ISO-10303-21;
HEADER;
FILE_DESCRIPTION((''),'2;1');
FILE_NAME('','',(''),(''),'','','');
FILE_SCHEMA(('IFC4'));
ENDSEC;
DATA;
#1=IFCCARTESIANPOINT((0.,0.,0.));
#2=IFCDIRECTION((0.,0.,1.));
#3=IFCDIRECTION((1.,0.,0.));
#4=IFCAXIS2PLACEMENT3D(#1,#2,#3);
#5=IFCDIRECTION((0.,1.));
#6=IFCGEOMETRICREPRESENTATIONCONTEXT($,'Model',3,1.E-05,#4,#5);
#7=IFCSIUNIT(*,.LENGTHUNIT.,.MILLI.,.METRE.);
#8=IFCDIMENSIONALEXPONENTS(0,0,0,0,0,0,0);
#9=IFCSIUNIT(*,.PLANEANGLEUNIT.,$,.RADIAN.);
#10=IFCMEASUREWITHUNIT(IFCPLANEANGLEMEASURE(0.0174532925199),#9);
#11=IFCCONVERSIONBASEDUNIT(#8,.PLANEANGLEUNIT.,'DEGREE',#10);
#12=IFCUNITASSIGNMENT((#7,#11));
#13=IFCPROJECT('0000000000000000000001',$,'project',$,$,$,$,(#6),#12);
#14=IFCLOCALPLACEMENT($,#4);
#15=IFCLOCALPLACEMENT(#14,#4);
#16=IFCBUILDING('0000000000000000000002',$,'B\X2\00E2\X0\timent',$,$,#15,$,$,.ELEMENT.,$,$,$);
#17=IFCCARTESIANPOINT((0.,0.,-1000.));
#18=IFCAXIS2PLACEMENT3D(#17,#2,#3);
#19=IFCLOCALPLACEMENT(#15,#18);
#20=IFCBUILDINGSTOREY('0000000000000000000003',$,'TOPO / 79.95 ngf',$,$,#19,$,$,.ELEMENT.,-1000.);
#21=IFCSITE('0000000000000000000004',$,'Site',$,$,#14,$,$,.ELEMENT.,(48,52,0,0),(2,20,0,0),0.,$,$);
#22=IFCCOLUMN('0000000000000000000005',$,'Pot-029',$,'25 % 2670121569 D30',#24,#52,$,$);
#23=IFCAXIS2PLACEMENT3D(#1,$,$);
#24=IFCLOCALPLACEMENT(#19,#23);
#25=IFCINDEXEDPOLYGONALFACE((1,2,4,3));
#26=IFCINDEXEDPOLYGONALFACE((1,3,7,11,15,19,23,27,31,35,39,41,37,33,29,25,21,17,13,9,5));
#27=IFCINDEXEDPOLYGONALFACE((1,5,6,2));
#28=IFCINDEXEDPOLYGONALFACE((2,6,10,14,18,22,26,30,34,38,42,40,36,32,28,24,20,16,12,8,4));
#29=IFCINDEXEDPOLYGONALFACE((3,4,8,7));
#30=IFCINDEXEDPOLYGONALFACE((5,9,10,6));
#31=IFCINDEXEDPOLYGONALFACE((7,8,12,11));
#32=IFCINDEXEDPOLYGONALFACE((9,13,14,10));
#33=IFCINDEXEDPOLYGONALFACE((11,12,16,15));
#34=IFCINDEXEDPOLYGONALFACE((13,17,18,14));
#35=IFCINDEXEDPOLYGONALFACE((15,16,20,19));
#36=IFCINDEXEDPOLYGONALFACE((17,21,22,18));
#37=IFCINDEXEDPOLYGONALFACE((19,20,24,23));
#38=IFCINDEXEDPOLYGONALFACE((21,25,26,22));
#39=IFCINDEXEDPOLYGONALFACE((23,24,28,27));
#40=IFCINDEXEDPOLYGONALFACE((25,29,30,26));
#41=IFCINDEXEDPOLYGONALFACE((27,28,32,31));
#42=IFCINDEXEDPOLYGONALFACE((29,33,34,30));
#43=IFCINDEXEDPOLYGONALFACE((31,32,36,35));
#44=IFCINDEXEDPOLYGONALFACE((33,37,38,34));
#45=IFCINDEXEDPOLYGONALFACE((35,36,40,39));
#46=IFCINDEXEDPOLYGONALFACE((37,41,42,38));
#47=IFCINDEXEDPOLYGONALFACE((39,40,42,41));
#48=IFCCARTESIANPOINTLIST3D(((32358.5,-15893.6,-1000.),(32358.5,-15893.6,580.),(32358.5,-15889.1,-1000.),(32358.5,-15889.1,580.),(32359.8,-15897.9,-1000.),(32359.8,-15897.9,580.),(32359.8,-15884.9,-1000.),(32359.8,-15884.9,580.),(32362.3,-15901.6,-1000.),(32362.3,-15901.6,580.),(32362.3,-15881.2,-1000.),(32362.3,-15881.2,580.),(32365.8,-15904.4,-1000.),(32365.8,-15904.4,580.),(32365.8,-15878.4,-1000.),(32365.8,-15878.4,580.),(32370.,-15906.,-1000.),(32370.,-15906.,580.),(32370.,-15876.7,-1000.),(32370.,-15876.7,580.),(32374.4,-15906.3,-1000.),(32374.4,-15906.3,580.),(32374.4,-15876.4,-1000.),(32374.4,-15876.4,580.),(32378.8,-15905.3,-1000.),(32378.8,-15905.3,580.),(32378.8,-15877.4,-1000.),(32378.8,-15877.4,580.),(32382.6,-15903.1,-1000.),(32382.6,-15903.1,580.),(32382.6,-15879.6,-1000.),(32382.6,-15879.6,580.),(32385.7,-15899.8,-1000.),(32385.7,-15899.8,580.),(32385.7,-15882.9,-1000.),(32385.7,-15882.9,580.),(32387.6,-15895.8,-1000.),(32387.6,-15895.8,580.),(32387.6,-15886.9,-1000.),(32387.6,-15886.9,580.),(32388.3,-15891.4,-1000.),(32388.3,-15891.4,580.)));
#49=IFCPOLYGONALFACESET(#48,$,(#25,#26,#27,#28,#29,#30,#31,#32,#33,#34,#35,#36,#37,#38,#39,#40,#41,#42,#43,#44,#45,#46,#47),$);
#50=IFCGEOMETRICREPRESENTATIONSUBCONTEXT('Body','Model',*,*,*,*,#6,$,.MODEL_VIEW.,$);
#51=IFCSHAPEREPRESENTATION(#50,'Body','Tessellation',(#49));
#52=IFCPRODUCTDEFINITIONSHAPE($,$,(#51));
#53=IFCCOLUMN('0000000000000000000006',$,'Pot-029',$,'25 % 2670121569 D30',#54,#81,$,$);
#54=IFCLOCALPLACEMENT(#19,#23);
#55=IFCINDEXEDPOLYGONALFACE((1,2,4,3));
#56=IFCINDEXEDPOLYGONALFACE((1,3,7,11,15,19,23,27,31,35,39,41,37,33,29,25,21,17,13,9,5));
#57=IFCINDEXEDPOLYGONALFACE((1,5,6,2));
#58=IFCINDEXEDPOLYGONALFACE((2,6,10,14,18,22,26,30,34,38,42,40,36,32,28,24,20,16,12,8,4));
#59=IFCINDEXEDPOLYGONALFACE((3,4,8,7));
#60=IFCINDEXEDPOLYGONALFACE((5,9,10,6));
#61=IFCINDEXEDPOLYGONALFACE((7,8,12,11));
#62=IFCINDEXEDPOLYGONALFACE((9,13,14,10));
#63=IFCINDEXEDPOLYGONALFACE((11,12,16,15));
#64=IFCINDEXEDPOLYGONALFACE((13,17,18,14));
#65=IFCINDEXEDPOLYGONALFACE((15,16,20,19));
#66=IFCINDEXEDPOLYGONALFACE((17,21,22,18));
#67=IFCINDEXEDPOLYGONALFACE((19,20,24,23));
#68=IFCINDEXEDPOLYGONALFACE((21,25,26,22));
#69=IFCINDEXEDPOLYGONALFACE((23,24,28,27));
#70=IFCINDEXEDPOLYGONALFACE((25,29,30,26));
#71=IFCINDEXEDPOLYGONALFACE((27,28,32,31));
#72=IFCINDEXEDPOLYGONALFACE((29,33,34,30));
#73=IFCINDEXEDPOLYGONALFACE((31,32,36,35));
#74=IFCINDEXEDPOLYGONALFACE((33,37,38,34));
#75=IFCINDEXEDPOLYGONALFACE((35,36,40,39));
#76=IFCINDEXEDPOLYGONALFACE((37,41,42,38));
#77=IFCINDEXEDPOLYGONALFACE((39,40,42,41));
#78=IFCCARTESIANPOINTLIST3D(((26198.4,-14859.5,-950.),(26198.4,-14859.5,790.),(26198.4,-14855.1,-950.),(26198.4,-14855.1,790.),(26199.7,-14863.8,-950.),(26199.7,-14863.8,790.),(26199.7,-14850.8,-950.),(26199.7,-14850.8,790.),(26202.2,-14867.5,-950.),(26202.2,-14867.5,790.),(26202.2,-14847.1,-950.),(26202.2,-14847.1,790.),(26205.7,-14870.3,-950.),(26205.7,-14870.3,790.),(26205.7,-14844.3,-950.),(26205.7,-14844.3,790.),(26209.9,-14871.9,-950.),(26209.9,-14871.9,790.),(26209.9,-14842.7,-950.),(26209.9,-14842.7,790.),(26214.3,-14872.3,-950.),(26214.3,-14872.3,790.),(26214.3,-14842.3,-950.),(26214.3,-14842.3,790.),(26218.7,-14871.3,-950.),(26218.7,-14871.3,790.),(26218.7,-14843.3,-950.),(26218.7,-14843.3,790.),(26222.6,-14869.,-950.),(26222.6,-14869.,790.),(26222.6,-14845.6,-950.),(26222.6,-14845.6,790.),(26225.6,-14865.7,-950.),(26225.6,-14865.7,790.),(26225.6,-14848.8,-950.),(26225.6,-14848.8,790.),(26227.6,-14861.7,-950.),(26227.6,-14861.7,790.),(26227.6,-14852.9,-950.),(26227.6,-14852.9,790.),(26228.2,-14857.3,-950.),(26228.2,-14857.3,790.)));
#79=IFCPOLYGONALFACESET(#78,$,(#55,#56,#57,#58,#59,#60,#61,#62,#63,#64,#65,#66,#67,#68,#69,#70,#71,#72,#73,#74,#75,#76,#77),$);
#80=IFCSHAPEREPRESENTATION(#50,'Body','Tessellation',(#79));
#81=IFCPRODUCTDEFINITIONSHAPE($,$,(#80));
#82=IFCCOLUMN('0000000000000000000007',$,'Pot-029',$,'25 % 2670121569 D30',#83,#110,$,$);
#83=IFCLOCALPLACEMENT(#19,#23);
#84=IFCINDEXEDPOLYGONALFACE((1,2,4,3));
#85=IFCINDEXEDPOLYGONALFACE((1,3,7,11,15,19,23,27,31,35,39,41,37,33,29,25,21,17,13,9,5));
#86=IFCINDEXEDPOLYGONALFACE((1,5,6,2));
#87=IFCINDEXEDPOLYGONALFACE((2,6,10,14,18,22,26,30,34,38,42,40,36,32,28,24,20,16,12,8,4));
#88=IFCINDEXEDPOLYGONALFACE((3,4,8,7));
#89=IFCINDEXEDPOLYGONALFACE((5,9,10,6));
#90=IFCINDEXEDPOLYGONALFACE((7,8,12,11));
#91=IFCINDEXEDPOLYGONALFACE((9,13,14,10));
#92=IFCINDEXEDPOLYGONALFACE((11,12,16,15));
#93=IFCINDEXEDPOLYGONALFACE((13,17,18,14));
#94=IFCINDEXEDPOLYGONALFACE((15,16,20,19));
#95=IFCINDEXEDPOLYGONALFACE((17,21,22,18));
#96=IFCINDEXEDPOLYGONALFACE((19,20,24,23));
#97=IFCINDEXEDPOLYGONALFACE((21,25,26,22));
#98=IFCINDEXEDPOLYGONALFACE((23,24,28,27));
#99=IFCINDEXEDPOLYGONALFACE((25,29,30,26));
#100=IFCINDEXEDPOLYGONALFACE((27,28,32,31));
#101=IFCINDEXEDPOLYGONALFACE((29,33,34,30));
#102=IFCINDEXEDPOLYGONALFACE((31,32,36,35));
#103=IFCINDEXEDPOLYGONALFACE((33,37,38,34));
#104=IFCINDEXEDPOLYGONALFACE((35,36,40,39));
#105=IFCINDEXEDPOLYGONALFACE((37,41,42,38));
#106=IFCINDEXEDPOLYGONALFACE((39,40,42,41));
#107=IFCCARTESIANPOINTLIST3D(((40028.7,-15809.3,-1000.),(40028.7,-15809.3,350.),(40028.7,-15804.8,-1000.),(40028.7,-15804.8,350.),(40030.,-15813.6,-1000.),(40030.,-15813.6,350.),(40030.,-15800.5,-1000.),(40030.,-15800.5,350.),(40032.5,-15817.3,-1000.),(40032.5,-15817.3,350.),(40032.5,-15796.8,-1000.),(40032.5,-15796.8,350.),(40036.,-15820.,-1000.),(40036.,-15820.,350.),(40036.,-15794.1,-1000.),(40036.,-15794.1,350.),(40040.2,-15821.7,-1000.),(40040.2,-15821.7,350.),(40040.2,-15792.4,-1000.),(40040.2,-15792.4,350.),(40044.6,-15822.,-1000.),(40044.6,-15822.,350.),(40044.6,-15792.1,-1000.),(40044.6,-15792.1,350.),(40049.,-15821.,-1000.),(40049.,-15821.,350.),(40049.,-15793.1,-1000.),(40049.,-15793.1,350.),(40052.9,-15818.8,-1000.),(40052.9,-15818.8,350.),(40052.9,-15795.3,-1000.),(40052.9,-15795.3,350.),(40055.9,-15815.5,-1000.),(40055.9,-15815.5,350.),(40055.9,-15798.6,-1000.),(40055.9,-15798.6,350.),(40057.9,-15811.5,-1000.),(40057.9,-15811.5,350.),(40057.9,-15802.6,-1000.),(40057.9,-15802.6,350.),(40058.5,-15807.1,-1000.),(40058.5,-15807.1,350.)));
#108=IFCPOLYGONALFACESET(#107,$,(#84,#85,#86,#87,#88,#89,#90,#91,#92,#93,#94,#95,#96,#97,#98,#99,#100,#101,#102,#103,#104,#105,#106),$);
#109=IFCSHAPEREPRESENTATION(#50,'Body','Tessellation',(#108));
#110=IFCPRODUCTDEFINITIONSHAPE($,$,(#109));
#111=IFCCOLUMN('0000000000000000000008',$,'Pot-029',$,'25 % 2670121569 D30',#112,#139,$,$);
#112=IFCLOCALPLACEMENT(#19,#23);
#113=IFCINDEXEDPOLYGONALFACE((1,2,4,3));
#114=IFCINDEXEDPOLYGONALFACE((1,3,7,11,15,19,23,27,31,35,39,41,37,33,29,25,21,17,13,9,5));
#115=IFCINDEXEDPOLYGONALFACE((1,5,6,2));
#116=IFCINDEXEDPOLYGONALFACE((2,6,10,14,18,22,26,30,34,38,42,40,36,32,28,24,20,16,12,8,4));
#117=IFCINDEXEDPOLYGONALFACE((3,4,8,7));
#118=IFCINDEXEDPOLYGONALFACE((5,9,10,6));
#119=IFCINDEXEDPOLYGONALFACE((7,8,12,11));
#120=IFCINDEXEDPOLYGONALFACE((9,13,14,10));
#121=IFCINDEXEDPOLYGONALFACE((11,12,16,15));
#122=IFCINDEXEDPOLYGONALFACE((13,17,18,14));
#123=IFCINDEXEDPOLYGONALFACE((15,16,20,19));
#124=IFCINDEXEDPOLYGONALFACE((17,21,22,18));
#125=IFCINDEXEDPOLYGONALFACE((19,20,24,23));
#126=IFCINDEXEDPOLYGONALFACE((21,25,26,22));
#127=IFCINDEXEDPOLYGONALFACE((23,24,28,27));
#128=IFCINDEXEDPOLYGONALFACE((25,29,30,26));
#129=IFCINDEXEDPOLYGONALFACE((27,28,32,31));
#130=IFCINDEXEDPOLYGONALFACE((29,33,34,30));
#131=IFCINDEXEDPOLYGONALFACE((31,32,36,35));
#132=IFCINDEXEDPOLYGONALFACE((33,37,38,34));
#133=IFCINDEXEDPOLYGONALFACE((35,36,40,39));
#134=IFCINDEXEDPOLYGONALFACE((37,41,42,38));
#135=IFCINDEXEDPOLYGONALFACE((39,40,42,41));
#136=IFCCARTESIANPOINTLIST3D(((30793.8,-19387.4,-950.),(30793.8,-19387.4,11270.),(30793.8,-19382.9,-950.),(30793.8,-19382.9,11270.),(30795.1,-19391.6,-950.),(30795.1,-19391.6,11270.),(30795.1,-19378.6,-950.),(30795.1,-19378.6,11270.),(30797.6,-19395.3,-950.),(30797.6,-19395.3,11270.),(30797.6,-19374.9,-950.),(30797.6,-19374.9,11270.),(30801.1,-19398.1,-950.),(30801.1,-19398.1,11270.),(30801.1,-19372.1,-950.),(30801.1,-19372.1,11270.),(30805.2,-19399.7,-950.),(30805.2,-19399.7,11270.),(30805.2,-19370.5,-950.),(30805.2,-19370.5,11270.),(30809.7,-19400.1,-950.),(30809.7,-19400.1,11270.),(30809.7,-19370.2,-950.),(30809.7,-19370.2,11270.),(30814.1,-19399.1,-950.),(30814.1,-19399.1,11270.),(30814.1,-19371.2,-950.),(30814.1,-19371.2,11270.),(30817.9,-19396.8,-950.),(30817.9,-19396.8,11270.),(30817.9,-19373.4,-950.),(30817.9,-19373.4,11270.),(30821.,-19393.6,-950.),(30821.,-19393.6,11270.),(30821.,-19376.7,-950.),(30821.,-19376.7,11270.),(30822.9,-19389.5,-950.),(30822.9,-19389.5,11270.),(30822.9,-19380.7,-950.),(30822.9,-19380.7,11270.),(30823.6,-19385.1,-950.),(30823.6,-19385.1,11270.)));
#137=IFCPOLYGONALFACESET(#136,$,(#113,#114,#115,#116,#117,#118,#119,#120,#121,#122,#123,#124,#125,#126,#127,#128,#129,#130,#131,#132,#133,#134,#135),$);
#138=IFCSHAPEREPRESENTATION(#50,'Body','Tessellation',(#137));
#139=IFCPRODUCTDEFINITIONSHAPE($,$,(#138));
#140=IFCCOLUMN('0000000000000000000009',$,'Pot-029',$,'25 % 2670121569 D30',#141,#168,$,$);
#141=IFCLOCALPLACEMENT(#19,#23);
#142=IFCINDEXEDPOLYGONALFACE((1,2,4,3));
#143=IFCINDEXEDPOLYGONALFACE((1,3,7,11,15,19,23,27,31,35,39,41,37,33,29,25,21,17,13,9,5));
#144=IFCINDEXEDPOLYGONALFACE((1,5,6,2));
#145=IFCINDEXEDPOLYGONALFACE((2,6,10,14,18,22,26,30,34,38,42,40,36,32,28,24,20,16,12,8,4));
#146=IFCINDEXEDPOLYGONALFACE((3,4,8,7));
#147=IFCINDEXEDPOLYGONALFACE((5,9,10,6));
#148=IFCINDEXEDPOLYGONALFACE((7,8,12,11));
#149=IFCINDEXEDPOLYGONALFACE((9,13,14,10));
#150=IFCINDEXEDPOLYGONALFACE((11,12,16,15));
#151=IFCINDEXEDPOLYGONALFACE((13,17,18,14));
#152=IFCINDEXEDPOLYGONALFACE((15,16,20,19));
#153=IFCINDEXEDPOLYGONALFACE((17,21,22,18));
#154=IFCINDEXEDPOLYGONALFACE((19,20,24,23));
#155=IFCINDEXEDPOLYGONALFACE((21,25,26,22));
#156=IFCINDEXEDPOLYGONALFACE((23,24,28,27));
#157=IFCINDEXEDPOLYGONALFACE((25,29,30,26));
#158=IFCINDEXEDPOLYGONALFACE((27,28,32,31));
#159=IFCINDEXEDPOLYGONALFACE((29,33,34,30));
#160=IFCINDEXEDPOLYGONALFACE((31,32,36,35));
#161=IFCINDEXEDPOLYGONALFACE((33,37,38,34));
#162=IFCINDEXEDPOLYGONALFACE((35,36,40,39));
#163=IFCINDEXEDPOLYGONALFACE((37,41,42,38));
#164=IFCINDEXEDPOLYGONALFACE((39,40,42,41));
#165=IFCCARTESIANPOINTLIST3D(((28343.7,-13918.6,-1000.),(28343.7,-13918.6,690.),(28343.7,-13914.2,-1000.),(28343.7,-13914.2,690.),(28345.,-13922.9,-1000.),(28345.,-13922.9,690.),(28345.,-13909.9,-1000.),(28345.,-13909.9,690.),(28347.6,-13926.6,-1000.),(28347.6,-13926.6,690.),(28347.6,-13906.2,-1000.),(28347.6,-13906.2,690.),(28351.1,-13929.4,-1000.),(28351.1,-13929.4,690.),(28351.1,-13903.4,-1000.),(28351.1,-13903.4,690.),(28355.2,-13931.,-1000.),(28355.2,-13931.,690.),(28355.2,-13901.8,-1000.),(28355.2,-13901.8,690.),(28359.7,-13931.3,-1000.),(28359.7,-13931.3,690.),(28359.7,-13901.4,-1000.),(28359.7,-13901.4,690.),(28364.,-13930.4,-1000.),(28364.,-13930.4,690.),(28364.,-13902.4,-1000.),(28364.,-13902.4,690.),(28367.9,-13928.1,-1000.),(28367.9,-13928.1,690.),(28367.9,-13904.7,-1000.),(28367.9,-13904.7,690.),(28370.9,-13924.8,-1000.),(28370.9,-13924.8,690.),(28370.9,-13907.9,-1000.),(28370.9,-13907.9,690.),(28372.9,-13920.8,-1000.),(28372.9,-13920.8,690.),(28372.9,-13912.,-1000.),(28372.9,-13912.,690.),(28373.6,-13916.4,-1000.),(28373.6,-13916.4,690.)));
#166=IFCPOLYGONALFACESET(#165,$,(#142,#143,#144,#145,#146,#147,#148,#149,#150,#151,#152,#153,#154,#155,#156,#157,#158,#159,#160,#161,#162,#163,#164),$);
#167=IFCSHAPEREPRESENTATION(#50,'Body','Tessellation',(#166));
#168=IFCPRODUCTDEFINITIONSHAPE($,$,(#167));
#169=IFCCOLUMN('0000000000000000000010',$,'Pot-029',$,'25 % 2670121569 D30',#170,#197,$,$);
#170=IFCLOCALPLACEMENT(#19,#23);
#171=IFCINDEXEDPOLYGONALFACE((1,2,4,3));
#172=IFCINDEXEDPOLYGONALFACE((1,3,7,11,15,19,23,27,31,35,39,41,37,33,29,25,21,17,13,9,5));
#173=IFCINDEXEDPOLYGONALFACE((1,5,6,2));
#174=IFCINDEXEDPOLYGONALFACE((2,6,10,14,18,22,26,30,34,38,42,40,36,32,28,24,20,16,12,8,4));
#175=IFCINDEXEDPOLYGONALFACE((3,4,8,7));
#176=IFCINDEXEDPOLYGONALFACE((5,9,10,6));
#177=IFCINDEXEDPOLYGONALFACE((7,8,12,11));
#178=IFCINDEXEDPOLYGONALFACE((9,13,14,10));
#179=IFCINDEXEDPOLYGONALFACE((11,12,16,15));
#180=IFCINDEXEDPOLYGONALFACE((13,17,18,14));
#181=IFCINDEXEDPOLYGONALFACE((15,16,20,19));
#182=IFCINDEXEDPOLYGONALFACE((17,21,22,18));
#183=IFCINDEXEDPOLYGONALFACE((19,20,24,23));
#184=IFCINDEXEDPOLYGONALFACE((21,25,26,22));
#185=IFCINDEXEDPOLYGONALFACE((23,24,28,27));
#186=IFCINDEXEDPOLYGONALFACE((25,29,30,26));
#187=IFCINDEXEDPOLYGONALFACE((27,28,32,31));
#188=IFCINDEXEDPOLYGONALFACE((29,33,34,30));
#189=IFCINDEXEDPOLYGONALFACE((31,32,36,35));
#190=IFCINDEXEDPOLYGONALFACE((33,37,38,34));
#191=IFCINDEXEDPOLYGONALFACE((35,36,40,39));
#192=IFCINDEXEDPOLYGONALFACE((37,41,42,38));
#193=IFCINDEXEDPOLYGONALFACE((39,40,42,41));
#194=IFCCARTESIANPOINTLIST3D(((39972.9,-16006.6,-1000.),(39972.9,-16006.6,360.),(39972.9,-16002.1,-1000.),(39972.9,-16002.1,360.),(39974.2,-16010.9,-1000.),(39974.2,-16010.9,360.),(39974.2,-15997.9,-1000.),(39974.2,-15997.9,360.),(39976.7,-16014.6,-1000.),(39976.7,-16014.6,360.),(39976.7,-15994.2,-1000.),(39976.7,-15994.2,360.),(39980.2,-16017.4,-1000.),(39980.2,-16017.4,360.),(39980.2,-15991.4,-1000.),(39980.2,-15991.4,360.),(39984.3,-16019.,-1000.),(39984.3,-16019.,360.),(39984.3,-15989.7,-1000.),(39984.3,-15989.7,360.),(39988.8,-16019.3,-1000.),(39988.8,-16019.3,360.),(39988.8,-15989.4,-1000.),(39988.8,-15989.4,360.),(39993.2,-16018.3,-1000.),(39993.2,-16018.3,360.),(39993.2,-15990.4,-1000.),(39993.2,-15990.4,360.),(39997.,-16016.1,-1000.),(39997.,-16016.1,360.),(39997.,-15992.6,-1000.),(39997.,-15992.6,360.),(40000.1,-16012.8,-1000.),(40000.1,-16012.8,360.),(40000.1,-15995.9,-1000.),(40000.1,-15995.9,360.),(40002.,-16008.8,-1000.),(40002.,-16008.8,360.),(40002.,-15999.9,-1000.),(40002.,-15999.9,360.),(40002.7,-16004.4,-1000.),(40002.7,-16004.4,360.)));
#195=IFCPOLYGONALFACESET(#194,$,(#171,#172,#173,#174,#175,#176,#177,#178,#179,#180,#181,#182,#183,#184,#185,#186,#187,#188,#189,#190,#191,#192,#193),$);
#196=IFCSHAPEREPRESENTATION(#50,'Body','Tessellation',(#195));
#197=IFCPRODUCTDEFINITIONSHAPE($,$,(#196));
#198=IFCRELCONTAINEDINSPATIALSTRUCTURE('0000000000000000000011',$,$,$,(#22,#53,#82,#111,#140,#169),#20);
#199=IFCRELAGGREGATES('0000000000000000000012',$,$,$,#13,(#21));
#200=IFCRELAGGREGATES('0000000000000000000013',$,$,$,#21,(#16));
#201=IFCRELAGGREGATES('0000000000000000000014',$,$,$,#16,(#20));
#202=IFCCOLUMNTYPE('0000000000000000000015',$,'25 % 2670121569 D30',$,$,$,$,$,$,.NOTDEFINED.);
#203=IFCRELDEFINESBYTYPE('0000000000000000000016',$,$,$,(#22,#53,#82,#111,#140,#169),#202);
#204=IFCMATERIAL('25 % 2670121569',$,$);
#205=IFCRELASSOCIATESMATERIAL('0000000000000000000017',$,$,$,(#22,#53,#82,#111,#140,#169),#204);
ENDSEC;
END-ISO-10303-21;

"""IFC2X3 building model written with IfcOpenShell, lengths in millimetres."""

from ifc_helpers import new_model, entity, si_unit, converted_unit, direction, frame, origin_with_axes, origin_2d_with_axis, place, context, subcontext, project, spatial, circle, extrude, material, type_object, element, save


model = new_model("IFC2X3")

# Units and contexts
model_context = context("Model", 3, precision=1e-05, world=origin_with_axes(), true_north=direction((0.0, 1.0)))
body_context = subcontext(model_context, "Body", "Model", "MODEL_VIEW")
ifc_project = project(units=[si_unit("LENGTHUNIT", "METRE", prefix="MILLI"), converted_unit("PLANEANGLEUNIT", "DEGREE", entity("IfcPlaneAngleMeasure", 0.0174532925199), si_unit("PLANEANGLEUNIT", "RADIAN"), dimensions=[0, 0, 0, 0, 0, 0, 0])], contexts=[model_context])

# Site, building, storey
site_placement = place(None, origin_with_axes())
site = spatial("IfcSite", under=ifc_project, at=site_placement, Name="Site", CompositionType="ELEMENT", RefLatitude=(48, 52, 0, 0), RefLongitude=(2, 20, 0, 0), RefElevation=0.0)
building_placement = place(site_placement, origin_with_axes())
building = spatial("IfcBuilding", under=site, at=building_placement, Name="Bâtiment", CompositionType="ELEMENT")
storey_placement = place(building_placement, frame((0.0, 0.0, -1000.0), z_axis=(0.0, 0.0, 1.0), x_axis=(1.0, 0.0, 0.0)))
storey = spatial("IfcBuildingStorey", under=building, at=storey_placement, Name="TOPO / 79.95 ngf", CompositionType="ELEMENT", Elevation=-1000.0)

# Columns
ifc_material_1 = material(Name="25 % 2670121569")
column_type_1 = type_object("IfcColumnType", Name="25 % 2670121569 D30", PredefinedType="NOTDEFINED")
column_1_placement = place(storey_placement, frame((32373.3, -15891.4, -1000.0), z_axis=(0.0, 0.0, 1.0), x_axis=(1.0, 0.0, 0.0)))
element("IfcColumn", 1, at=column_1_placement, inside=storey, type_object=column_type_1, material=ifc_material_1, Name="Pot-029", ObjectType="25 % 2670121569 D30", context=body_context, shape_type="SweptSolid", body=[
    extrude(circle(Radius=15.0, at=origin_2d_with_axis()), origin_with_axes(), (0.0, 0.0, 1.0), 1580.0),
])
column_2_placement = place(storey_placement, frame((26213.2, -14857.3, -950.0), z_axis=(0.0, 0.0, 1.0), x_axis=(1.0, 0.0, 0.0)))
element("IfcColumn", 2, at=column_2_placement, inside=storey, type_object=column_type_1, material=ifc_material_1, Name="Pot-029", ObjectType="25 % 2670121569 D30", context=body_context, shape_type="SweptSolid", body=[
    extrude(circle(Radius=15.0, at=origin_2d_with_axis()), origin_with_axes(), (0.0, 0.0, 1.0), 1740.0),
])
column_3_placement = place(storey_placement, frame((40043.5, -15807.1, -1000.0), z_axis=(0.0, 0.0, 1.0), x_axis=(1.0, 0.0, 0.0)))
element("IfcColumn", 3, at=column_3_placement, inside=storey, type_object=column_type_1, material=ifc_material_1, Name="Pot-029", ObjectType="25 % 2670121569 D30", context=body_context, shape_type="SweptSolid", body=[
    extrude(circle(Radius=15.0, at=origin_2d_with_axis()), origin_with_axes(), (0.0, 0.0, 1.0), 1350.0),
])
column_4_placement = place(storey_placement, frame((30808.6, -19385.1, -950.0), z_axis=(0.0, 0.0, 1.0), x_axis=(1.0, 0.0, 0.0)))
element("IfcColumn", 4, at=column_4_placement, inside=storey, type_object=column_type_1, material=ifc_material_1, Name="Pot-029", ObjectType="25 % 2670121569 D30", context=body_context, shape_type="SweptSolid", body=[
    extrude(circle(Radius=15.0, at=origin_2d_with_axis()), origin_with_axes(), (0.0, 0.0, 1.0), 12220.0),
])
column_5_placement = place(storey_placement, frame((28358.6, -13916.4, -1000.0), z_axis=(0.0, 0.0, 1.0), x_axis=(1.0, 0.0, 0.0)))
element("IfcColumn", 5, at=column_5_placement, inside=storey, type_object=column_type_1, material=ifc_material_1, Name="Pot-029", ObjectType="25 % 2670121569 D30", context=body_context, shape_type="SweptSolid", body=[
    extrude(circle(Radius=15.0, at=origin_2d_with_axis()), origin_with_axes(), (0.0, 0.0, 1.0), 1690.0),
])
column_6_placement = place(storey_placement, frame((39987.7, -16004.4, -1000.0), z_axis=(0.0, 0.0, 1.0), x_axis=(1.0, 0.0, 0.0)))
element("IfcColumn", 6, at=column_6_placement, inside=storey, type_object=column_type_1, material=ifc_material_1, Name="Pot-029", ObjectType="25 % 2670121569 D30", context=body_context, shape_type="SweptSolid", body=[
    extrude(circle(Radius=15.0, at=origin_2d_with_axis()), origin_with_axes(), (0.0, 0.0, 1.0), 1360.0),
])

save(model, "model.ifc")
